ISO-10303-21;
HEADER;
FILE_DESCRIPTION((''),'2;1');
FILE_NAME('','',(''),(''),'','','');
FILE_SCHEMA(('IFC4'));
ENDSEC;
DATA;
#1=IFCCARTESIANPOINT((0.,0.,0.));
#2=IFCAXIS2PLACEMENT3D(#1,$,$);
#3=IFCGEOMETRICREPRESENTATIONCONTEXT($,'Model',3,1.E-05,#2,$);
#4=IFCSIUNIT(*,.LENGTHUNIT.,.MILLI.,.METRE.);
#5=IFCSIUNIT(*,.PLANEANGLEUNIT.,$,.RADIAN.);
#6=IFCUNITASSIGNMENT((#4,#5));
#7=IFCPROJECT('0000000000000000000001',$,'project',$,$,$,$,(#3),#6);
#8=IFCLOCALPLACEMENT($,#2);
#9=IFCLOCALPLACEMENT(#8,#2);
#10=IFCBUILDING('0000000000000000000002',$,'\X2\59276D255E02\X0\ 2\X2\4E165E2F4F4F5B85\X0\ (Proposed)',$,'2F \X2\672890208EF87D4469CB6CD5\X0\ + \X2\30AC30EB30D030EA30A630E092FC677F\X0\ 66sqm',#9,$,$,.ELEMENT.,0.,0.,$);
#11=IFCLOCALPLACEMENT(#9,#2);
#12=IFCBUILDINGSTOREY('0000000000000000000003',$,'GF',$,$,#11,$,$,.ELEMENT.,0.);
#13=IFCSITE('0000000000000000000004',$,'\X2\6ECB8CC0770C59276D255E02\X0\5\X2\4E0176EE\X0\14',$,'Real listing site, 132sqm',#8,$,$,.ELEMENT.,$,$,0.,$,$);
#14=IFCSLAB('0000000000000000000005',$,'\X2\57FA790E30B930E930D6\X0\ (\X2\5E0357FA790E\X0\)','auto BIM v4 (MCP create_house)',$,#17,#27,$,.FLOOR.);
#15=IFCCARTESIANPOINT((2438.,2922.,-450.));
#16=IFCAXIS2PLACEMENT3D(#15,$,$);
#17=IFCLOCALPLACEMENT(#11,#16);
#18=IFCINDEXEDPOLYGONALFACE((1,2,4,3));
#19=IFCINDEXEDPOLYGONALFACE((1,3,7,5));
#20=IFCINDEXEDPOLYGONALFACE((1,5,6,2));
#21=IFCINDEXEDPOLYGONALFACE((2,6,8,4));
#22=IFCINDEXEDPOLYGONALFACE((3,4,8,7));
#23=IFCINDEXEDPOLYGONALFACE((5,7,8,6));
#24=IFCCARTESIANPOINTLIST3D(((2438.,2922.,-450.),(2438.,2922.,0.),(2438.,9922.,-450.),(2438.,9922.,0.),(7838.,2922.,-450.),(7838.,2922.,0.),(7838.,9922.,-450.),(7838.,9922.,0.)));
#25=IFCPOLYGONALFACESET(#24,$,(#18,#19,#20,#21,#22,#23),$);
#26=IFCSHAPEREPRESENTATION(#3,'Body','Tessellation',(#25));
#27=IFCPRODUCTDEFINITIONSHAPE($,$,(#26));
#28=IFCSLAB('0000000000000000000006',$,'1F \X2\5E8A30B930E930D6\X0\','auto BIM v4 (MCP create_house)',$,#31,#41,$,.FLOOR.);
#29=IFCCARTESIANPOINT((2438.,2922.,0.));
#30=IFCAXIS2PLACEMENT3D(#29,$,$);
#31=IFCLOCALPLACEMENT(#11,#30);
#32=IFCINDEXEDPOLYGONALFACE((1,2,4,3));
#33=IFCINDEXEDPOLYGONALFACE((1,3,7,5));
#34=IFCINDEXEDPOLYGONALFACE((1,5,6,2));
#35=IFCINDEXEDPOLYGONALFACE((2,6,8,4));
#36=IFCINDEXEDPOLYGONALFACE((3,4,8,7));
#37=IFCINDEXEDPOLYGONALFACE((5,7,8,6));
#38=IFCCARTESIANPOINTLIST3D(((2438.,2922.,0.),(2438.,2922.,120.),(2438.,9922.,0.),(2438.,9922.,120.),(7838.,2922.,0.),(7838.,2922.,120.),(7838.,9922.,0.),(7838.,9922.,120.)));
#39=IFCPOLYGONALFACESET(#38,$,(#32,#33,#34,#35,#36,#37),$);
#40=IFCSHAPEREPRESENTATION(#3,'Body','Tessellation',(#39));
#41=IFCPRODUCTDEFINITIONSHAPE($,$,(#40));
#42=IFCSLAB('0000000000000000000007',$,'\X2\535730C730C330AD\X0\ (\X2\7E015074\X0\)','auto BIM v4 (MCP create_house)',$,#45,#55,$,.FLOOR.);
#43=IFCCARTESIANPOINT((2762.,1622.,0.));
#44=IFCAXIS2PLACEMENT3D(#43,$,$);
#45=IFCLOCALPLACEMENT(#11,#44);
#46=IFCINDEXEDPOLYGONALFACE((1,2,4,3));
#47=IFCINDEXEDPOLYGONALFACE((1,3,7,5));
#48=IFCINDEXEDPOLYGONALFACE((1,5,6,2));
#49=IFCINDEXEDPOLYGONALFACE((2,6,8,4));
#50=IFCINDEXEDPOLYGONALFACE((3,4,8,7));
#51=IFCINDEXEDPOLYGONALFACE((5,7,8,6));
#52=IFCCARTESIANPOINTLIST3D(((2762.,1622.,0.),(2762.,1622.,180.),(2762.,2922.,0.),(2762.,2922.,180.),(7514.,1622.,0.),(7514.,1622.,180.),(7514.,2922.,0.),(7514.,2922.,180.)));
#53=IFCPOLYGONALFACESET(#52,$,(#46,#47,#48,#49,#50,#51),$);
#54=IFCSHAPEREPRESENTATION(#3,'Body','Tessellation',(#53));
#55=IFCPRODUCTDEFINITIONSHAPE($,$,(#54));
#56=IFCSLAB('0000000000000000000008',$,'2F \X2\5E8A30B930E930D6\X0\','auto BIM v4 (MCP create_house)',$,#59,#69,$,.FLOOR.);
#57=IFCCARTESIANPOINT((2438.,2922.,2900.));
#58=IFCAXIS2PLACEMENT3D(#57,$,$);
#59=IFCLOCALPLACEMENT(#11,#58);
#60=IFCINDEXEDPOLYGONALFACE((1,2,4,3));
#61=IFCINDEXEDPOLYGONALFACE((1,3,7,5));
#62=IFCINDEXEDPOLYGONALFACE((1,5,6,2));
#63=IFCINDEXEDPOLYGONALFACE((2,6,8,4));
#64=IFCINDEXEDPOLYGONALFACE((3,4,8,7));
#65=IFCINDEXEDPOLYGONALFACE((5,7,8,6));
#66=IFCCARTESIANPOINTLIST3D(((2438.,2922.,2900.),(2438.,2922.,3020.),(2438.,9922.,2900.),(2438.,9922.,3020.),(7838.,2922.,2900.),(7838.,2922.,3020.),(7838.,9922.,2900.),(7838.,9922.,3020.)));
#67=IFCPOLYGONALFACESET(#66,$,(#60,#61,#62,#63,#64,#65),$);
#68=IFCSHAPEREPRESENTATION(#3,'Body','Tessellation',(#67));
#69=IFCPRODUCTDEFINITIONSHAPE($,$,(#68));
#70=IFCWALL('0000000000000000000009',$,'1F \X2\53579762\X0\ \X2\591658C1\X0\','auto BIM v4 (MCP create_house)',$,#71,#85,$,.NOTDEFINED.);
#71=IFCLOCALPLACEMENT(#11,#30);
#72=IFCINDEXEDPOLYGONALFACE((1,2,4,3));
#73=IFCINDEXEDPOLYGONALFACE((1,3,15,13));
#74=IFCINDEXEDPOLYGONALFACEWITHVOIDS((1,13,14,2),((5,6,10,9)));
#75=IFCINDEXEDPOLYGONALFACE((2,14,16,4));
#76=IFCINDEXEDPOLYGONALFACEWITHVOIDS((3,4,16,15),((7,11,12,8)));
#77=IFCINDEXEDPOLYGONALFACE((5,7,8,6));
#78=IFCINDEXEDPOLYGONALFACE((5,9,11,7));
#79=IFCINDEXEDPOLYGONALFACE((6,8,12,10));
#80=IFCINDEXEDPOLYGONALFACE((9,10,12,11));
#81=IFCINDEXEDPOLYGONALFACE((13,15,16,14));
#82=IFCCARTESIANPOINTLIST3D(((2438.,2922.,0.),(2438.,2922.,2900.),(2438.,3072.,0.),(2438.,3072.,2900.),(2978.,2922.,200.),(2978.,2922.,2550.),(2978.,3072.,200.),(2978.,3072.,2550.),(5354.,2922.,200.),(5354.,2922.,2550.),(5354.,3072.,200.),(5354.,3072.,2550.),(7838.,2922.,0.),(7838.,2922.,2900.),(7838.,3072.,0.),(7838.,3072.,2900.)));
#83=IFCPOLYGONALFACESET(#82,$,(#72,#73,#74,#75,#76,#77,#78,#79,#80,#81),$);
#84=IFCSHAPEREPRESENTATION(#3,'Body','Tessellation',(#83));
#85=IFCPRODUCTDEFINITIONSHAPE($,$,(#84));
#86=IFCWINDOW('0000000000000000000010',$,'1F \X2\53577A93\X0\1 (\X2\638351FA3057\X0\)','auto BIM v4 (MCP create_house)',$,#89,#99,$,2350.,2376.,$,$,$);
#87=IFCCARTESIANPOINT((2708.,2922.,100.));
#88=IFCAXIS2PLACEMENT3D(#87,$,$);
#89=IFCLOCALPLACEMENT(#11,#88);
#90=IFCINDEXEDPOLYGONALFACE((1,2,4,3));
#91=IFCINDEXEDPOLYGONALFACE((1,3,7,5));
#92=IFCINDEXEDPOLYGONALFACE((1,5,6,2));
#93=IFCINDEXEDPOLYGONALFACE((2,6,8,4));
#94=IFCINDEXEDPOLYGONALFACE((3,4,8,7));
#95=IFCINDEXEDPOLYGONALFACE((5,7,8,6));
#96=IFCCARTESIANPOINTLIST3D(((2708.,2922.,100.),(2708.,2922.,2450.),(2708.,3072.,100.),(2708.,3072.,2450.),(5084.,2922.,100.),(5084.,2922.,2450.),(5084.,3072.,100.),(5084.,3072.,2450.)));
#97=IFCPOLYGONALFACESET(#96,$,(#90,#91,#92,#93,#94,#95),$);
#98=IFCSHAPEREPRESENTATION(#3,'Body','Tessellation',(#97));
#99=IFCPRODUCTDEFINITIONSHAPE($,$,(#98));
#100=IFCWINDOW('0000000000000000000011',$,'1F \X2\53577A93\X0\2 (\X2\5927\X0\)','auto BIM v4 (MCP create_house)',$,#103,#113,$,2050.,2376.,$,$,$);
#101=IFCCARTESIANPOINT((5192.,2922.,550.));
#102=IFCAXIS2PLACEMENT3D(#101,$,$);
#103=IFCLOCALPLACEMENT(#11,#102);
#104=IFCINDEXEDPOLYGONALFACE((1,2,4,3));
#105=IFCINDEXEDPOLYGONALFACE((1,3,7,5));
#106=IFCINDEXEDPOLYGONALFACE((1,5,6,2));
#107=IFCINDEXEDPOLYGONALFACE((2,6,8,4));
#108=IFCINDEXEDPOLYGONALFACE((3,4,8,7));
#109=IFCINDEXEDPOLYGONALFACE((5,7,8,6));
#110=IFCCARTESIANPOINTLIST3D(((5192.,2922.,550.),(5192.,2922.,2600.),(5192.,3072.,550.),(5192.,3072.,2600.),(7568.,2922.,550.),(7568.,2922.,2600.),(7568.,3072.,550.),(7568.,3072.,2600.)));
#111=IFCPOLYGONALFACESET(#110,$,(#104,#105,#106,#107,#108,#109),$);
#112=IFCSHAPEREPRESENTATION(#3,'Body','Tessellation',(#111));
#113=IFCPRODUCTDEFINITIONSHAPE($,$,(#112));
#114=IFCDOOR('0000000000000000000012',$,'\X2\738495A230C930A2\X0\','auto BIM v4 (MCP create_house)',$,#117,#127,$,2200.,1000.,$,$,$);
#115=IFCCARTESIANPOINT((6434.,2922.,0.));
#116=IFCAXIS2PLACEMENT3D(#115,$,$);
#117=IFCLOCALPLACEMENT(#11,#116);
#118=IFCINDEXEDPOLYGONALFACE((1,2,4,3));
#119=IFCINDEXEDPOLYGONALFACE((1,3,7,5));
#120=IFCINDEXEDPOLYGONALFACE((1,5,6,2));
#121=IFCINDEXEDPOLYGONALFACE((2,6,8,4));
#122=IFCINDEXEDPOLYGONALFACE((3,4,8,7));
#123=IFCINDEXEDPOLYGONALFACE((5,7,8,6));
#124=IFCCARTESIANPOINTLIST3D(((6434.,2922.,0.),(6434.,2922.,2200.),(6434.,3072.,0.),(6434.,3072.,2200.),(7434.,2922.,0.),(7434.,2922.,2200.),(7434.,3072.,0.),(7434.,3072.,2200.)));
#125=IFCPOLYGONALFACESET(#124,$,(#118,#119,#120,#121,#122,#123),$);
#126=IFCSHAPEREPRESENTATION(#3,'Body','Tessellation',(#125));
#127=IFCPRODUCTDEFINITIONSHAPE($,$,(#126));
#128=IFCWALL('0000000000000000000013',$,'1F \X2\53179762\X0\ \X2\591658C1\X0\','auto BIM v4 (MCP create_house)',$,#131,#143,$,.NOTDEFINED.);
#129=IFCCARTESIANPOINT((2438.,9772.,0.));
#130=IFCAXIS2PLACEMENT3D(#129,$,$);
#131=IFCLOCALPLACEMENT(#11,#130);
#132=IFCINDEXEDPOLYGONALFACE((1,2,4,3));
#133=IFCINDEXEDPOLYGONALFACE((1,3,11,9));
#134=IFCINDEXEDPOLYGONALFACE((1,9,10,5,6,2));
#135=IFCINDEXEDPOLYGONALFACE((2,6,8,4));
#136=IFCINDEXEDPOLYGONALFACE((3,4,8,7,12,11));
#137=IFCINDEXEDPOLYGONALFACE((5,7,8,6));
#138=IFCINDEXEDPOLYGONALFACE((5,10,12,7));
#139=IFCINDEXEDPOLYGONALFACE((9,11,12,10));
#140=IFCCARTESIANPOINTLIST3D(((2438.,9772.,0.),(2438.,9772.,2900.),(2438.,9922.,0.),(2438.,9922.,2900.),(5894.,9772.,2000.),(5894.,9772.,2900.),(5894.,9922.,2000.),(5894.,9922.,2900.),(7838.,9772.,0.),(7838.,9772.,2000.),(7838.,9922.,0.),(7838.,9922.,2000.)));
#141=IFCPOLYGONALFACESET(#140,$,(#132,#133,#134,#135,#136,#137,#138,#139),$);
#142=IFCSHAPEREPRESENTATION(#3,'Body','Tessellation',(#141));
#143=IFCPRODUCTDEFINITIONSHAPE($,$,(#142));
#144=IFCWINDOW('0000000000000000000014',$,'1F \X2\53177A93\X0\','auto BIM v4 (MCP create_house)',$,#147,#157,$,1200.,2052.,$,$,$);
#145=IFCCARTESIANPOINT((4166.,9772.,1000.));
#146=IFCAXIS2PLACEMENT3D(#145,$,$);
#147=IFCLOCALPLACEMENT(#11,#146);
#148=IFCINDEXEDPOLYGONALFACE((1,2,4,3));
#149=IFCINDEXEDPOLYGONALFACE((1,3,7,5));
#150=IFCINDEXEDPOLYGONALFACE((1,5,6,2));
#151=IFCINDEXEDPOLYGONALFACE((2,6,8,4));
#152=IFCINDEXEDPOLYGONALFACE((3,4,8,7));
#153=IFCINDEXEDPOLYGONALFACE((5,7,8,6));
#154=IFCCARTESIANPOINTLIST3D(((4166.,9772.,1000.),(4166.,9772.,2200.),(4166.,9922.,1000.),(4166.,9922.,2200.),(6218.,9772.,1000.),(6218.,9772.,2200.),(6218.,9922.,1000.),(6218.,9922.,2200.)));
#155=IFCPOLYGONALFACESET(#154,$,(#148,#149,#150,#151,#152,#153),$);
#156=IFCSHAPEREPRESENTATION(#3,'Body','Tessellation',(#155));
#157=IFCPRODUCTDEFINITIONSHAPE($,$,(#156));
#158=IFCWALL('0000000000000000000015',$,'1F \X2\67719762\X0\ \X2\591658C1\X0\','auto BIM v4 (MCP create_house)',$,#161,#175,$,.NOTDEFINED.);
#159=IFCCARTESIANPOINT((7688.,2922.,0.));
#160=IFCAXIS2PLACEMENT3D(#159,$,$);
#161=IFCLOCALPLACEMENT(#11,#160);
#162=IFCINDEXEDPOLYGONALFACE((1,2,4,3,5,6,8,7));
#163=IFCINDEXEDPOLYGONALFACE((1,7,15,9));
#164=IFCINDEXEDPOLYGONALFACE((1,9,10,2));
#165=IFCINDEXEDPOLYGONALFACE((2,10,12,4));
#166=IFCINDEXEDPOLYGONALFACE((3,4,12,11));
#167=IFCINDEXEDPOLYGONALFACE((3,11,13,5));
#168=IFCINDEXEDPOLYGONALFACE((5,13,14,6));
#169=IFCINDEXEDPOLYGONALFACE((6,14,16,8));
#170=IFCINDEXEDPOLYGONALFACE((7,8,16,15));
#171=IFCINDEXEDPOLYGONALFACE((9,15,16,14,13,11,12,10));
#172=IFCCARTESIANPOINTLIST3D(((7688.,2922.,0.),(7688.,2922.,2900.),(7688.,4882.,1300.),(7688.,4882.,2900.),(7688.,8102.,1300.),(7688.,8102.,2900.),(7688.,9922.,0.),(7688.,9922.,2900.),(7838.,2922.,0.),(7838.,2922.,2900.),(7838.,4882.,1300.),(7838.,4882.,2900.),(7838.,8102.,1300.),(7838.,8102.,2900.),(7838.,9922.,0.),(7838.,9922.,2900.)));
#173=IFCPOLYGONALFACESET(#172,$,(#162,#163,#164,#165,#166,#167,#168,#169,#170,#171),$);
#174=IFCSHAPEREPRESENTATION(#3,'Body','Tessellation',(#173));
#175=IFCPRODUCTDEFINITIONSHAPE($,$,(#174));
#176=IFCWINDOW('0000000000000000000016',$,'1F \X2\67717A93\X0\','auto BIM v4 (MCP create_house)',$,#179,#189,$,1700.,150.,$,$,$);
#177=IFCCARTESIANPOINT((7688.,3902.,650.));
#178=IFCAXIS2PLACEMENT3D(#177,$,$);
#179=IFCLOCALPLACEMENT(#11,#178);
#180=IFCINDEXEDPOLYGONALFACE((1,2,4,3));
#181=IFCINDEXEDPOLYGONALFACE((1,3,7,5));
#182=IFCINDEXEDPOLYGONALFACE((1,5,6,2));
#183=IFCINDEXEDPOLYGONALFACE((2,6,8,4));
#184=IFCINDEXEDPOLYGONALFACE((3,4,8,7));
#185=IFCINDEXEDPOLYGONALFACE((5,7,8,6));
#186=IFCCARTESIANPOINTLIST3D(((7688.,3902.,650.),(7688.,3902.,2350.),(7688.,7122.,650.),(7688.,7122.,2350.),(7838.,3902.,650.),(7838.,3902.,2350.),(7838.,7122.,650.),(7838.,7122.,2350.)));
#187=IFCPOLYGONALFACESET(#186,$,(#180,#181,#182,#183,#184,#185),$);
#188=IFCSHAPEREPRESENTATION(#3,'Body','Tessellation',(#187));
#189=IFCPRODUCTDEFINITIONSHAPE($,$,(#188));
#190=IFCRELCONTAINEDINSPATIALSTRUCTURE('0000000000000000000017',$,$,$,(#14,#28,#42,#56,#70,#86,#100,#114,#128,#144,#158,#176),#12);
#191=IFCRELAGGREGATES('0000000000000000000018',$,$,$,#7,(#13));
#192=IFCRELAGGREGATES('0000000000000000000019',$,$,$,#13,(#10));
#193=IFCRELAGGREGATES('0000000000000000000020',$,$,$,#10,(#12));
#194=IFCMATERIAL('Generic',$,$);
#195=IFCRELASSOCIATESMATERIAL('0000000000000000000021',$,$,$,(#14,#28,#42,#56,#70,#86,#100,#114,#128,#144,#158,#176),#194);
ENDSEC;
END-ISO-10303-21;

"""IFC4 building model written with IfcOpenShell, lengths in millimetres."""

from ifc_helpers import new_model, si_unit, frame, frame_2d, origin, place, context, project, spatial, rectangle, extrude, material, element, fill, save


model = new_model("IFC4")

# Units and contexts
model_context = context("Model", 3, precision=1e-05, world=origin())
ifc_project = project(units=[si_unit("LENGTHUNIT", "METRE", prefix="MILLI"), si_unit("PLANEANGLEUNIT", "RADIAN")], contexts=[model_context])

# Site, building, storey
site_placement = place(None, origin())
site = spatial("IfcSite", under=ifc_project, at=site_placement, Name="滋賀県大津市5丁目14", ObjectType="Real listing site, 132sqm", CompositionType="ELEMENT", RefElevation=0.0)
building_placement = place(site_placement, origin())
building = spatial("IfcBuilding", under=site, at=building_placement, Name="大津市 2世帯住宅 (Proposed)", ObjectType="2F 木造軸組構法 + ガルバリウム鋼板 66sqm", CompositionType="ELEMENT", ElevationOfRefHeight=0.0, ElevationOfTerrain=0.0)
storey_placement = place(building_placement, origin())
storey = spatial("IfcBuildingStorey", under=building, at=storey_placement, Name="GF", CompositionType="ELEMENT", Elevation=0.0)

# Slabs
ifc_material = material(Name="Generic")
slab_1_placement = place(storey_placement, frame((2438.0, 2922.0, -450.0)))
element("IfcSlab", 1, at=slab_1_placement, inside=storey, material=ifc_material, Name="基礎スラブ (布基礎)", Description="auto BIM v4 (MCP create_house)", PredefinedType="FLOOR", context=model_context, shape_type="SweptSolid", body=[
    extrude(rectangle(XDim=5400.0, YDim=7000.0, at=frame_2d((2700.0, 3500.0))), frame((2438.0, 2922.0, -450.0)), (0.0, 0.0, 1.0), 450.0),
])
slab_2_placement = place(storey_placement, frame((2438.0, 2922.0, 0.0)))
element("IfcSlab", 2, at=slab_2_placement, inside=storey, material=ifc_material, Name="1F 床スラブ", Description="auto BIM v4 (MCP create_house)", PredefinedType="FLOOR", context=model_context, shape_type="SweptSolid", body=[
    extrude(rectangle(XDim=5400.0, YDim=7000.0, at=frame_2d((2700.0, 3500.0))), frame((2438.0, 2922.0, 0.0)), (0.0, 0.0, 1.0), 120.0),
])
slab_3_placement = place(storey_placement, frame((2762.0, 1622.0, 0.0)))
element("IfcSlab", 3, at=slab_3_placement, inside=storey, material=ifc_material, Name="南デッキ (縁側)", Description="auto BIM v4 (MCP create_house)", PredefinedType="FLOOR", context=model_context, shape_type="SweptSolid", body=[
    extrude(rectangle(XDim=4752.0, YDim=1300.0, at=frame_2d((2376.0, 650.0))), frame((2762.0, 1622.0, 0.0)), (0.0, 0.0, 1.0), 180.0),
])
slab_4_placement = place(storey_placement, frame((2438.0, 2922.0, 2900.0)))
element("IfcSlab", 4, at=slab_4_placement, inside=storey, material=ifc_material, Name="2F 床スラブ", Description="auto BIM v4 (MCP create_house)", PredefinedType="FLOOR", context=model_context, shape_type="SweptSolid", body=[
    extrude(rectangle(XDim=5400.0, YDim=7000.0, at=frame_2d((2700.0, 3500.0))), frame((2438.0, 2922.0, 2900.0)), (0.0, 0.0, 1.0), 120.0),
])

# Wall, openings, windows, door
wall_1_placement = place(storey_placement, frame((2438.0, 2922.0, 0.0)))
wall_1 = element("IfcWall", 5, at=wall_1_placement, inside=storey, material=ifc_material, Name="1F 南面 外壁", Description="auto BIM v4 (MCP create_house)", PredefinedType="NOTDEFINED", context=model_context, shape_type="SweptSolid", body=[
    extrude(rectangle(XDim=5400.0, YDim=150.0, at=frame_2d((2700.0, 75.0))), frame((2438.0, 2922.0, 0.0)), (0.0, 0.0, 1.0), 2900.0),
])
opening_1_placement = place(storey_placement, frame((2708.0, 2922.0, 100.0)))
opening_1 = element("IfcOpeningElement", 6, at=opening_1_placement, cuts=wall_1, PredefinedType="NOTDEFINED", context=model_context, shape_type="SweptSolid", body=[
    extrude(rectangle(XDim=2376.0, YDim=150.0, at=frame_2d((1188.0, 75.0))), frame((2708.0, 2922.0, 100.0)), (0.0, 0.0, 1.0), 2350.0),
])
opening_2_placement = place(storey_placement, frame((5192.0, 2922.0, 550.0)))
opening_2 = element("IfcOpeningElement", 7, at=opening_2_placement, cuts=wall_1, PredefinedType="NOTDEFINED", context=model_context, shape_type="SweptSolid", body=[
    extrude(rectangle(XDim=2376.0, YDim=150.0, at=frame_2d((1188.0, 75.0))), frame((5192.0, 2922.0, 550.0)), (0.0, 0.0, 1.0), 2050.0),
])
opening_3_placement = place(storey_placement, frame((6434.0, 2922.0, 0.0)))
opening_3 = element("IfcOpeningElement", 8, at=opening_3_placement, cuts=wall_1, PredefinedType="NOTDEFINED", context=model_context, shape_type="SweptSolid", body=[
    extrude(rectangle(XDim=1000.0, YDim=150.0, at=frame_2d((500.0, 75.0))), frame((6434.0, 2922.0, 0.0)), (0.0, 0.0, 1.0), 2200.0),
])
window_1_placement = place(storey_placement, frame((2708.0, 2922.0, 100.0)))
window_1 = element("IfcWindow", 9, at=window_1_placement, inside=storey, material=ifc_material, Name="1F 南窓1 (掃出し)", Description="auto BIM v4 (MCP create_house)", OverallHeight=2350.0, OverallWidth=2376.0, context=model_context, shape_type="SweptSolid", body=[
    extrude(rectangle(XDim=2376.0, YDim=150.0, at=frame_2d((1188.0, 75.0))), frame((2708.0, 2922.0, 100.0)), (0.0, 0.0, 1.0), 2350.0),
])
fill(opening_1, window_1)
window_2_placement = place(storey_placement, frame((5192.0, 2922.0, 550.0)))
window_2 = element("IfcWindow", 10, at=window_2_placement, inside=storey, material=ifc_material, Name="1F 南窓2 (大)", Description="auto BIM v4 (MCP create_house)", OverallHeight=2050.0, OverallWidth=2376.0, context=model_context, shape_type="SweptSolid", body=[
    extrude(rectangle(XDim=2376.0, YDim=150.0, at=frame_2d((1188.0, 75.0))), frame((5192.0, 2922.0, 550.0)), (0.0, 0.0, 1.0), 2050.0),
])
fill(opening_2, window_2)
door_1_placement = place(storey_placement, frame((6434.0, 2922.0, 0.0)))
door_1 = element("IfcDoor", 11, at=door_1_placement, inside=storey, material=ifc_material, Name="玄関ドア", Description="auto BIM v4 (MCP create_house)", OverallHeight=2200.0, OverallWidth=1000.0, context=model_context, shape_type="SweptSolid", body=[
    extrude(rectangle(XDim=1000.0, YDim=150.0, at=frame_2d((500.0, 75.0))), frame((6434.0, 2922.0, 0.0)), (0.0, 0.0, 1.0), 2200.0),
])
fill(opening_3, door_1)

# Walls, openings, windows
wall_2_placement = place(storey_placement, frame((2438.0, 9772.0, 0.0)))
wall_2 = element("IfcWall", 12, at=wall_2_placement, inside=storey, material=ifc_material, Name="1F 北面 外壁", Description="auto BIM v4 (MCP create_house)", PredefinedType="NOTDEFINED", context=model_context, shape_type="SweptSolid", body=[
    extrude(rectangle(XDim=5400.0, YDim=150.0, at=frame_2d((2700.0, 75.0))), frame((2438.0, 9772.0, 0.0)), (0.0, 0.0, 1.0), 2900.0),
])
opening_4_placement = place(storey_placement, frame((4166.0, 9772.0, 1000.0)))
opening_4 = element("IfcOpeningElement", 13, at=opening_4_placement, cuts=wall_2, PredefinedType="NOTDEFINED", context=model_context, shape_type="SweptSolid", body=[
    extrude(rectangle(XDim=2052.0, YDim=150.0, at=frame_2d((1026.0, 75.0))), frame((4166.0, 9772.0, 1000.0)), (0.0, 0.0, 1.0), 1200.0),
])
window_3_placement = place(storey_placement, frame((4166.0, 9772.0, 1000.0)))
window_3 = element("IfcWindow", 14, at=window_3_placement, inside=storey, material=ifc_material, Name="1F 北窓", Description="auto BIM v4 (MCP create_house)", OverallHeight=1200.0, OverallWidth=2052.0, context=model_context, shape_type="SweptSolid", body=[
    extrude(rectangle(XDim=2052.0, YDim=150.0, at=frame_2d((1026.0, 75.0))), frame((4166.0, 9772.0, 1000.0)), (0.0, 0.0, 1.0), 1200.0),
])
fill(opening_4, window_3)
wall_3_placement = place(storey_placement, frame((7688.0, 2922.0, 0.0)))
wall_3 = element("IfcWall", 15, at=wall_3_placement, inside=storey, material=ifc_material, Name="1F 東面 外壁", Description="auto BIM v4 (MCP create_house)", PredefinedType="NOTDEFINED", context=model_context, shape_type="SweptSolid", body=[
    extrude(rectangle(XDim=150.0, YDim=7000.0, at=frame_2d((75.0, 3500.0))), frame((7688.0, 2922.0, 0.0)), (0.0, 0.0, 1.0), 2900.0),
])
opening_5_placement = place(storey_placement, frame((7688.0, 3902.0, 650.0)))
opening_5 = element("IfcOpeningElement", 16, at=opening_5_placement, cuts=wall_3, PredefinedType="NOTDEFINED", context=model_context, shape_type="SweptSolid", body=[
    extrude(rectangle(XDim=150.0, YDim=3220.0, at=frame_2d((75.0, 1610.0))), frame((7688.0, 3902.0, 650.0)), (0.0, 0.0, 1.0), 1700.0),
])
window_4_placement = place(storey_placement, frame((7688.0, 3902.0, 650.0)))
window_4 = element("IfcWindow", 17, at=window_4_placement, inside=storey, material=ifc_material, Name="1F 東窓", Description="auto BIM v4 (MCP create_house)", OverallHeight=1700.0, OverallWidth=150.0, context=model_context, shape_type="SweptSolid", body=[
    extrude(rectangle(XDim=150.0, YDim=3220.0, at=frame_2d((75.0, 1610.0))), frame((7688.0, 3902.0, 650.0)), (0.0, 0.0, 1.0), 1700.0),
])
fill(opening_5, window_4)

save(model, "model.ifc")
